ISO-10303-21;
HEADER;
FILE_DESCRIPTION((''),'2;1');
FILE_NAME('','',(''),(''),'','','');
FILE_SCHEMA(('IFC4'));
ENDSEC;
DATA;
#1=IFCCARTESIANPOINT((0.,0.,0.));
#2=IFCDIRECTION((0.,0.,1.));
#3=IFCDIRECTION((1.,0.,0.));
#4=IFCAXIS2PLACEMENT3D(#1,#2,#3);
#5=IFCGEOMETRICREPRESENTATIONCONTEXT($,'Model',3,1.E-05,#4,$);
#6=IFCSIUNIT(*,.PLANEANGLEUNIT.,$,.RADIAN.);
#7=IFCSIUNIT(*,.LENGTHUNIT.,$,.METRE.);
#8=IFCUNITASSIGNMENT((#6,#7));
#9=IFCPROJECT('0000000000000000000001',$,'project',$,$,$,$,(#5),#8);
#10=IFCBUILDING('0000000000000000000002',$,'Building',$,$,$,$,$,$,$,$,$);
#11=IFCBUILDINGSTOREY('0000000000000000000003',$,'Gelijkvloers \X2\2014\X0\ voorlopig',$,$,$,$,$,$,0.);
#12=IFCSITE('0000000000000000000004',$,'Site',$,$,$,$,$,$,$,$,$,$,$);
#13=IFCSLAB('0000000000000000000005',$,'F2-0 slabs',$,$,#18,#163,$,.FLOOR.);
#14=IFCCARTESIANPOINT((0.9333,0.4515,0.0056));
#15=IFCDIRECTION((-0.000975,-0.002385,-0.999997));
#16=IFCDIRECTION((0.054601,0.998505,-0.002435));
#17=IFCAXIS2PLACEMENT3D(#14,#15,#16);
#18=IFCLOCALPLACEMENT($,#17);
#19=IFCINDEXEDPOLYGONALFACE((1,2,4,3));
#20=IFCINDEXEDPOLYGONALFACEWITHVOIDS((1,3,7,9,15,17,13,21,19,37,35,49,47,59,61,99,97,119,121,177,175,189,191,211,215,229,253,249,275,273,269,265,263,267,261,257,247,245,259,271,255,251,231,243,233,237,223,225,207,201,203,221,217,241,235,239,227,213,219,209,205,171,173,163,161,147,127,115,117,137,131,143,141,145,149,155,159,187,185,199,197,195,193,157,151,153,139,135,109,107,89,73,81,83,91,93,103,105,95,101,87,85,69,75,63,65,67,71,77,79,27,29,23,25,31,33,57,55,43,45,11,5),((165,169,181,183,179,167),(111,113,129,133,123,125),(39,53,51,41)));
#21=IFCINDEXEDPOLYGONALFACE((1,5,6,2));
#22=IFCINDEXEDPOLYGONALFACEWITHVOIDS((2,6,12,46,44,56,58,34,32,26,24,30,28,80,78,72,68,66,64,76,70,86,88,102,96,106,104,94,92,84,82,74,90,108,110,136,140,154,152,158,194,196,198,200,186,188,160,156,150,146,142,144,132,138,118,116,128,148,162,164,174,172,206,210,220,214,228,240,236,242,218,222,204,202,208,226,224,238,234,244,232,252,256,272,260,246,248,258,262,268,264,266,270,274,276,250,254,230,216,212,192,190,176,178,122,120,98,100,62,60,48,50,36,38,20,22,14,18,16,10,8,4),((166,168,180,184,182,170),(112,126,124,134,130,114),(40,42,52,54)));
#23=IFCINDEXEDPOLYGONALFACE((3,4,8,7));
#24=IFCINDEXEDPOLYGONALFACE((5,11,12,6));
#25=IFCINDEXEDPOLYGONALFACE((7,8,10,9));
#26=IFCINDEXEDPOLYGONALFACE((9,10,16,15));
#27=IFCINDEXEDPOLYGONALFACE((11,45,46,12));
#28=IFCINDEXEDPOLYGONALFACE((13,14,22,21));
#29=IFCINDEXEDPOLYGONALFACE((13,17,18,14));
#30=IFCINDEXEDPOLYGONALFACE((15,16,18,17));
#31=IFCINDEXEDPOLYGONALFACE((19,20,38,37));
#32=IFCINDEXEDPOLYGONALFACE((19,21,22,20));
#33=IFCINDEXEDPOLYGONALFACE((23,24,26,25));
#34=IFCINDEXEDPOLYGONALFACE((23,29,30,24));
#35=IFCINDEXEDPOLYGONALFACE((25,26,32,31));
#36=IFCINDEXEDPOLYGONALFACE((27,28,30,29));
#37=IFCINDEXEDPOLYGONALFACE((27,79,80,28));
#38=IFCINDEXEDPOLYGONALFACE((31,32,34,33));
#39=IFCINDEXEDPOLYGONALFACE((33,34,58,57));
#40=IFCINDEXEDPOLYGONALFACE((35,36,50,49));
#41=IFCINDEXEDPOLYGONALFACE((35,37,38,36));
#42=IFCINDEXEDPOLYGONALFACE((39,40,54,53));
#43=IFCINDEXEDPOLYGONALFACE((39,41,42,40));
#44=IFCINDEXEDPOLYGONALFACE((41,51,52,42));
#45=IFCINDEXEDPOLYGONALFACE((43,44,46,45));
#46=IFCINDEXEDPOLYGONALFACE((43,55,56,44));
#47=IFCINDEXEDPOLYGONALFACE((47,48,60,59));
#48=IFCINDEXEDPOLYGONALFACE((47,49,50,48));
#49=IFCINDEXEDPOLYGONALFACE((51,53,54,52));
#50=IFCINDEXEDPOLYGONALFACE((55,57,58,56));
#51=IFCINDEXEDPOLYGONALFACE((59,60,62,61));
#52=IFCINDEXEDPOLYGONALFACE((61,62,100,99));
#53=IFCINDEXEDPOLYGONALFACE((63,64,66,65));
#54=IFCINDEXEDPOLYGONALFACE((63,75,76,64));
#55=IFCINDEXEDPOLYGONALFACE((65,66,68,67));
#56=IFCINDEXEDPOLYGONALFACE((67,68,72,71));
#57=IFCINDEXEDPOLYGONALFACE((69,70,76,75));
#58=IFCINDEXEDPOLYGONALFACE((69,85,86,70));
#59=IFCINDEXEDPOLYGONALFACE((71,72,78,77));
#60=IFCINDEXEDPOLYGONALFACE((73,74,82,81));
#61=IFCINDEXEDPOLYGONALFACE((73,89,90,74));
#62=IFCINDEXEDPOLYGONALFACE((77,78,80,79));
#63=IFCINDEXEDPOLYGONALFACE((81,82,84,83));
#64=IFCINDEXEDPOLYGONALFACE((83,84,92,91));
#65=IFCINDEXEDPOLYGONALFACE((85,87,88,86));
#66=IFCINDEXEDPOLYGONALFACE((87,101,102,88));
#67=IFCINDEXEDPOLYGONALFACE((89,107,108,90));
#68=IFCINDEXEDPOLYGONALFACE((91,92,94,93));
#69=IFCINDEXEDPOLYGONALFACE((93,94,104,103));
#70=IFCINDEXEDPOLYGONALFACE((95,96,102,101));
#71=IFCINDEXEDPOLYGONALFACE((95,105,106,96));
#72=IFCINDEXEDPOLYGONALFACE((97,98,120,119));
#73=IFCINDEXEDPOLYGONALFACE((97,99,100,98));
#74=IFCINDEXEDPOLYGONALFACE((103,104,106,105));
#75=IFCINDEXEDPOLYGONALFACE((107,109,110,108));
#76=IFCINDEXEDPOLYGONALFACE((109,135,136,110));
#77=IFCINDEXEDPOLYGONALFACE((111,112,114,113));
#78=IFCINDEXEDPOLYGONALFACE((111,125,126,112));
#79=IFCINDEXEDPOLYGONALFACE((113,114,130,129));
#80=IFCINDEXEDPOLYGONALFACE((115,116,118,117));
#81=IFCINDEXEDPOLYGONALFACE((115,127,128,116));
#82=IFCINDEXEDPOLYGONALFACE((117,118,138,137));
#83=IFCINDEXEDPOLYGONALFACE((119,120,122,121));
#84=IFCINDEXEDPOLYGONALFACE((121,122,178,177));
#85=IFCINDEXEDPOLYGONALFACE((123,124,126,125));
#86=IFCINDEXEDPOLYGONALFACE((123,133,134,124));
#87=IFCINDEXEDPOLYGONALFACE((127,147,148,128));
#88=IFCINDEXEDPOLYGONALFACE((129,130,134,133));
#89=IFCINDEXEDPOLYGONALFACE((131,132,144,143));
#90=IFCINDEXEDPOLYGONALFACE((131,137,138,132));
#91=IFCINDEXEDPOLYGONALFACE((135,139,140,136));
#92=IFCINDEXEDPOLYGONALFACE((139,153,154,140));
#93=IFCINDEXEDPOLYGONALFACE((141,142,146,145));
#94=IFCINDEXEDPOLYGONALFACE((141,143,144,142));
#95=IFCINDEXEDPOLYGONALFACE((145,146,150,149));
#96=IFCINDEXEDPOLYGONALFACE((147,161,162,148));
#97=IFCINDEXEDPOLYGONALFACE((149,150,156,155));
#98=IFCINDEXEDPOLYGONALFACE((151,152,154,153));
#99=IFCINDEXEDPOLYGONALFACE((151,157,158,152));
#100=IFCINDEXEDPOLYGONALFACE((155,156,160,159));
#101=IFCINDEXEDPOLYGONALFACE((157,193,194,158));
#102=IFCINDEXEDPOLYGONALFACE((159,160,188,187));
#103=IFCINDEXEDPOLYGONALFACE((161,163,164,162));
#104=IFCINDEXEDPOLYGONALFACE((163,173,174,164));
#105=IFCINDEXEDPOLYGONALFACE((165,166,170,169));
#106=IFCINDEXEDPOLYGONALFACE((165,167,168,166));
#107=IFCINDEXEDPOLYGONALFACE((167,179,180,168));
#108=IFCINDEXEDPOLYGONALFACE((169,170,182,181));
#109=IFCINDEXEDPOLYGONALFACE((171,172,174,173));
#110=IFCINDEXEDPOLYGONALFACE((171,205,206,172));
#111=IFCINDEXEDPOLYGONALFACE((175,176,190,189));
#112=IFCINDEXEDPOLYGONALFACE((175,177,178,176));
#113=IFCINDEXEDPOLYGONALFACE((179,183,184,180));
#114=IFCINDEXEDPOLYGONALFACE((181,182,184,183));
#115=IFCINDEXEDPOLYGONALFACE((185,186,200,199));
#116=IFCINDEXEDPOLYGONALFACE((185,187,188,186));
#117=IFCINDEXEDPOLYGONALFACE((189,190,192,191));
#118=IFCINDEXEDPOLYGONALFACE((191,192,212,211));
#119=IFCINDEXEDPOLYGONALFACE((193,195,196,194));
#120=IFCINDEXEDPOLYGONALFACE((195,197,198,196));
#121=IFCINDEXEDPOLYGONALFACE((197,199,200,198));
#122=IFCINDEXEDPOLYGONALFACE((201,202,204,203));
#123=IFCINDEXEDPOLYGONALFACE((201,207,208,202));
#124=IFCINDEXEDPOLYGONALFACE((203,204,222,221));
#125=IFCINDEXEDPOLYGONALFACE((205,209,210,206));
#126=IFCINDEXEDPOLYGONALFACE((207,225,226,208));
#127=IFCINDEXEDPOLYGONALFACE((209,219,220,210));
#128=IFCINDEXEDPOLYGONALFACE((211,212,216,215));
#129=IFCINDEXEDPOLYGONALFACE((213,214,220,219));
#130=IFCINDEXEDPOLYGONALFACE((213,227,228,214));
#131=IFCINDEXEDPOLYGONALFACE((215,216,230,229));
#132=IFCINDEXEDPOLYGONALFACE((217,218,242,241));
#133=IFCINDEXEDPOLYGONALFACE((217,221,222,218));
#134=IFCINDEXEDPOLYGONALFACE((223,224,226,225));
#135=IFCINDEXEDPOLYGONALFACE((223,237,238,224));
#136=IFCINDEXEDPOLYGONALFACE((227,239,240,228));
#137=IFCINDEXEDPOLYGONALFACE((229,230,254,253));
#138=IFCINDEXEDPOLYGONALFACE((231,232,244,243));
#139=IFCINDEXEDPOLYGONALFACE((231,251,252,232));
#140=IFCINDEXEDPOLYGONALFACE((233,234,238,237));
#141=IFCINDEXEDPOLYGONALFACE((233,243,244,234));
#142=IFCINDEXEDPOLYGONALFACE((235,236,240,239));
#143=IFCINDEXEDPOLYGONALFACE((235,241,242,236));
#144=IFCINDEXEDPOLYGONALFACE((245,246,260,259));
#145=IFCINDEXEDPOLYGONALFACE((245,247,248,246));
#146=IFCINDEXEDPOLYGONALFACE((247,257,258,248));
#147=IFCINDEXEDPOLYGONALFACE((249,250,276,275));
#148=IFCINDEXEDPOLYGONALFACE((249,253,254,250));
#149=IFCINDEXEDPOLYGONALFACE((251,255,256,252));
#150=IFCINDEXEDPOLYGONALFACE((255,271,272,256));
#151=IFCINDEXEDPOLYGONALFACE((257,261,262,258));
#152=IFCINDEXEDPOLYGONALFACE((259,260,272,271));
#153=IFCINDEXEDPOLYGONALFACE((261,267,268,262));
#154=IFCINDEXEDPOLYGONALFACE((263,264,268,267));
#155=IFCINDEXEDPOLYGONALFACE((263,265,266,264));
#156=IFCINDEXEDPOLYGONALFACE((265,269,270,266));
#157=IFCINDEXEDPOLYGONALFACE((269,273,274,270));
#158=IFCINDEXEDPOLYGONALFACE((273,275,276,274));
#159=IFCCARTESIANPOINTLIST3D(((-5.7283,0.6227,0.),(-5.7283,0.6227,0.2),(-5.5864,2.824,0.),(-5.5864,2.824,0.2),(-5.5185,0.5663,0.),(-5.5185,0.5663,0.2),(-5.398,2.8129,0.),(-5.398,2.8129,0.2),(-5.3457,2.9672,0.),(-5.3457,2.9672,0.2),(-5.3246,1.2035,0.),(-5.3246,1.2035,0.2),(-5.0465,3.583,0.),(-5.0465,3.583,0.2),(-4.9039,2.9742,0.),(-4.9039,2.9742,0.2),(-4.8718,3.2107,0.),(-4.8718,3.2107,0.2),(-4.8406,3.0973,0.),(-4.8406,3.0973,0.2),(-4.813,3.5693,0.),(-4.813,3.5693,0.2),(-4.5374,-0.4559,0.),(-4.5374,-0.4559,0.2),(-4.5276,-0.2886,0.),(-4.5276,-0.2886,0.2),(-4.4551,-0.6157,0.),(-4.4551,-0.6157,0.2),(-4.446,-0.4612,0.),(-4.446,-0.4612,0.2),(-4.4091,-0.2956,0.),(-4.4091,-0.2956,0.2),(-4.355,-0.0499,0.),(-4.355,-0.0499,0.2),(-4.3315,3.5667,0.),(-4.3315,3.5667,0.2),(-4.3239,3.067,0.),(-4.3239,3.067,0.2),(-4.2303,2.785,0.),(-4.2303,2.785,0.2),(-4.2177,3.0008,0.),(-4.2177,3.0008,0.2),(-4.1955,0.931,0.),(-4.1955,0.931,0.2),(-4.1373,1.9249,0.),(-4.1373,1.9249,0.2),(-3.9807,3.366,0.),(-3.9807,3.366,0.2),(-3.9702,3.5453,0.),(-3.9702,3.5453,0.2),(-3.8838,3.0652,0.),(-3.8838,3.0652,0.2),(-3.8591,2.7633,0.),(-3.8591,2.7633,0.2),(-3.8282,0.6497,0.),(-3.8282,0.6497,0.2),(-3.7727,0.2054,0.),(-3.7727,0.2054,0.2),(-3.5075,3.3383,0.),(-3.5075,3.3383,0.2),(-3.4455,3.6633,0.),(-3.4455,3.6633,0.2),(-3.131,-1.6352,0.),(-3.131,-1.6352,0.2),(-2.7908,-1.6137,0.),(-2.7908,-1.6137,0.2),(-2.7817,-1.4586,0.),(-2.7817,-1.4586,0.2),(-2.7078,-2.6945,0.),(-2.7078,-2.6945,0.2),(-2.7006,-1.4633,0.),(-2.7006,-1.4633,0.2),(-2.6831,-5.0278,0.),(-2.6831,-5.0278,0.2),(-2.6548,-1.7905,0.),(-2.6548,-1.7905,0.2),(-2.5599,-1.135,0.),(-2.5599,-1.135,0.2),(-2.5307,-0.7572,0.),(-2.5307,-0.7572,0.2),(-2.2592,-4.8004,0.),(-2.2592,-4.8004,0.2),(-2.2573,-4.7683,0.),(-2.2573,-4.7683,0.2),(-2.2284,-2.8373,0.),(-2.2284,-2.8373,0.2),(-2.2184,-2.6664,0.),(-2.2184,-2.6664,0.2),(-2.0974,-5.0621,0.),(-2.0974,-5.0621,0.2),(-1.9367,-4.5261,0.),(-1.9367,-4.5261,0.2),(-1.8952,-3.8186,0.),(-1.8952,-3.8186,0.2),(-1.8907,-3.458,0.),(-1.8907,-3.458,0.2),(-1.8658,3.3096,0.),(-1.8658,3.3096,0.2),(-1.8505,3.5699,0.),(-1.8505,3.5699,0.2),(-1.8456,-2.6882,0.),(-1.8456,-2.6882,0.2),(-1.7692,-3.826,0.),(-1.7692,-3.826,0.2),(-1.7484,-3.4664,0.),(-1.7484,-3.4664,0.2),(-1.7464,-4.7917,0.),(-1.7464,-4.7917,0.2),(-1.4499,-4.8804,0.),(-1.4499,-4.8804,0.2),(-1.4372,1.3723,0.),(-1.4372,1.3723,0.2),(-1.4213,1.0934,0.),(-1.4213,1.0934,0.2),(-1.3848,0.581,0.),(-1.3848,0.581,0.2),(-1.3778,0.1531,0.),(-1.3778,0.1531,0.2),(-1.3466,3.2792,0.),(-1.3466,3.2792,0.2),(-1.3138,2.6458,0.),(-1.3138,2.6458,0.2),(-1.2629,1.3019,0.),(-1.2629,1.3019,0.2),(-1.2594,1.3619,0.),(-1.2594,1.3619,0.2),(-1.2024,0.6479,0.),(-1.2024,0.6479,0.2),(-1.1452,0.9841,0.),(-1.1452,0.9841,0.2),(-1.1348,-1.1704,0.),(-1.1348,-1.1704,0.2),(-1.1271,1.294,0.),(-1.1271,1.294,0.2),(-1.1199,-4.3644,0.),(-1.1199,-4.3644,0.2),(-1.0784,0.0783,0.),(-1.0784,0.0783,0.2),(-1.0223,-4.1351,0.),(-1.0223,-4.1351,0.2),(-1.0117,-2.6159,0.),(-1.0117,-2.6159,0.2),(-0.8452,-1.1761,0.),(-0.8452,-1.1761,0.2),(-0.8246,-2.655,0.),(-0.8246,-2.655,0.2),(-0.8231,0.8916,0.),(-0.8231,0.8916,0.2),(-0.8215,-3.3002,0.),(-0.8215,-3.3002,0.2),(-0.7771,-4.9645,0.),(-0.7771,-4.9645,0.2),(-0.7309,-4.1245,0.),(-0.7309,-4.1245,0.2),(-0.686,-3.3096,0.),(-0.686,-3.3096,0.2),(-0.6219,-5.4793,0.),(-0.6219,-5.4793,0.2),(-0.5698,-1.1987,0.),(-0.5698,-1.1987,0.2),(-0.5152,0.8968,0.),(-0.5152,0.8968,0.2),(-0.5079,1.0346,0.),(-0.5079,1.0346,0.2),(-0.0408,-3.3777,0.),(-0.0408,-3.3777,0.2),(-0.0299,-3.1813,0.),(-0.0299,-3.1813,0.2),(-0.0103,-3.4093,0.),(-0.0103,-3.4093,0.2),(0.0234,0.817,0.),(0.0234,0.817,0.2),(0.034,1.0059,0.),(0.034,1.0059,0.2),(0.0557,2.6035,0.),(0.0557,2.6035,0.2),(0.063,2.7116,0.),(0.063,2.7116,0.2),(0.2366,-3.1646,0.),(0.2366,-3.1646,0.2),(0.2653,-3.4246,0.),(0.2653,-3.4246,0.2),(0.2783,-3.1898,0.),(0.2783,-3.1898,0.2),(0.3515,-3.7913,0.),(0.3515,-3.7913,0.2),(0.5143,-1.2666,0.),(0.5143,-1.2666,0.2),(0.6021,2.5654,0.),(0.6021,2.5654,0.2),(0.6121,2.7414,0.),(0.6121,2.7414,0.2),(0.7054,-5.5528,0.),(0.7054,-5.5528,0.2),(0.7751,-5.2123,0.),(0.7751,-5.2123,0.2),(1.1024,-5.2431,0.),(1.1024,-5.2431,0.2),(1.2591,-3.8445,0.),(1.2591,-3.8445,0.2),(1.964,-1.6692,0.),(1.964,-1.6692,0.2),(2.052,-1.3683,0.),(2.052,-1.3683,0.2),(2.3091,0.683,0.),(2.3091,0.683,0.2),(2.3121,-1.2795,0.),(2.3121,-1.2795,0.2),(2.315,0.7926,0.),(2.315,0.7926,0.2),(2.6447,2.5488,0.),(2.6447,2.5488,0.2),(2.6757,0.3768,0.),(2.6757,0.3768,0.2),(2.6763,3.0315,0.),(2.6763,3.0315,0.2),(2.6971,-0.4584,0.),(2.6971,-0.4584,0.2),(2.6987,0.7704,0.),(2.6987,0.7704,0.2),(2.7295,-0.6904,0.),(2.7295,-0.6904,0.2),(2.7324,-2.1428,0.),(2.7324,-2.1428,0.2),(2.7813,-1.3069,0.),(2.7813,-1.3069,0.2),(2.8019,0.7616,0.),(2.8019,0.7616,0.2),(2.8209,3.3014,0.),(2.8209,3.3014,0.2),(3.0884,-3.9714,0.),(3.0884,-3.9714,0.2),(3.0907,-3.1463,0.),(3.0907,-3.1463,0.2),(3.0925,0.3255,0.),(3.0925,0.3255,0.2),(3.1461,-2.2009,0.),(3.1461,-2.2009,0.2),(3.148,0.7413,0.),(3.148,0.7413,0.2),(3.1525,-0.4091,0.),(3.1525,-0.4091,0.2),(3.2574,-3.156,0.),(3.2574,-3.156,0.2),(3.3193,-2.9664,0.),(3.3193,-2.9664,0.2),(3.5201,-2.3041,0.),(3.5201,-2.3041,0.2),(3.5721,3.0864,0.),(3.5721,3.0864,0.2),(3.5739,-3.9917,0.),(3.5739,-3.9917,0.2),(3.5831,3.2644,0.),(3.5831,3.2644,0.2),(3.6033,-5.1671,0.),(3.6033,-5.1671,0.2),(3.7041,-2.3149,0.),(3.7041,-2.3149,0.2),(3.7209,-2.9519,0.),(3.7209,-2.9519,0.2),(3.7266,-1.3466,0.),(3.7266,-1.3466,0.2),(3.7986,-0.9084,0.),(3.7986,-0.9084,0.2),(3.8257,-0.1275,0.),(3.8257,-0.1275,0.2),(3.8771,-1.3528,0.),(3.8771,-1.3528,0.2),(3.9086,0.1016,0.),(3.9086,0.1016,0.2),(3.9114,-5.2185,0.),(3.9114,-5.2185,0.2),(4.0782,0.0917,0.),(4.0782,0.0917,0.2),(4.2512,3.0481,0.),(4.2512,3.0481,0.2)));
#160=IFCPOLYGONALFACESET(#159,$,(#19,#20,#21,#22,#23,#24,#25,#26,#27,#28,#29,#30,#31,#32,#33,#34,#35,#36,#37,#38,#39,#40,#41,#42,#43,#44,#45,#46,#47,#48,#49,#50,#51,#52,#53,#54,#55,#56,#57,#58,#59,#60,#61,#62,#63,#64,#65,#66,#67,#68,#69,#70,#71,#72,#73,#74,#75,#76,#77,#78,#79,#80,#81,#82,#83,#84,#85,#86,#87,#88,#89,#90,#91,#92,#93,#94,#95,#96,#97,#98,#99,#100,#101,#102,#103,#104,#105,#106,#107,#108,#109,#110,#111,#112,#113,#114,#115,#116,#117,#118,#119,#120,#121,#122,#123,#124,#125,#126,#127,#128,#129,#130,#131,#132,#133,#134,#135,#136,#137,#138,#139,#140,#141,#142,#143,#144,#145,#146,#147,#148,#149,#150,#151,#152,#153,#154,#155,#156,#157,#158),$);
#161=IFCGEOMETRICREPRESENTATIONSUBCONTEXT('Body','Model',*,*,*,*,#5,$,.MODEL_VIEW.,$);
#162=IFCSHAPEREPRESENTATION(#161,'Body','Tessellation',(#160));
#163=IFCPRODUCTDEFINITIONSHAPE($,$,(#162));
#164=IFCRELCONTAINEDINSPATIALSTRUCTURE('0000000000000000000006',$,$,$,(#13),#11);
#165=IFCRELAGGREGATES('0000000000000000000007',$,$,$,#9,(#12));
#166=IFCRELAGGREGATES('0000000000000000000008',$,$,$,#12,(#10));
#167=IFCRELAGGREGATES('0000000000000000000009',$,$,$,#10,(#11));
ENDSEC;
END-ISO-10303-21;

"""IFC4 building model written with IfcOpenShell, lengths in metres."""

from ifc_helpers import new_model, si_unit, frame, origin_with_axes, place, context, subcontext, project, spatial, polyline, outline, extrude, element, save


model = new_model("IFC4")

# Units and contexts
model_context = context("Model", 3, precision=1e-05, world=origin_with_axes())
body_context = subcontext(model_context, "Body", "Model", "MODEL_VIEW")
ifc_project = project(units=[si_unit("PLANEANGLEUNIT", "RADIAN"), si_unit("LENGTHUNIT", "METRE")], contexts=[model_context])

# Site, building, storey
site = spatial("IfcSite", under=ifc_project, Name="Site")
building = spatial("IfcBuilding", under=site, Name="Building")
storey = spatial("IfcBuildingStorey", under=building, Name="Gelijkvloers — voorlopig", Elevation=0.0)

# Slab, openings
slab_placement = place(None, frame((0.9333, 0.4515, 0.0056), z_axis=(-0.000975, -0.002385, -0.999997), x_axis=(0.054601, 0.998505, -0.002435)))
slab = element("IfcSlab", 1, at=slab_placement, inside=storey, Name="F2-0 slabs", PredefinedType="FLOOR", context=body_context, shape_type="SweptSolid", body=[
    extrude(outline(polyline([(3.5831, 3.2644), (2.8209, 3.3014), (2.6763, 3.0315), (2.6447, 2.5488), (0.6121, 2.7414), (0.6021, 2.5654), (0.0557, 2.6035), (0.063, 2.7116), (-1.3138, 2.6458), (-1.3466, 3.2792), (-1.8658, 3.3096), (-1.8505, 3.5699), (-3.4455, 3.6633), (-3.5075, 3.3383), (-3.9807, 3.366), (-3.9702, 3.5453), (-4.3315, 3.5667), (-4.3239, 3.067), (-4.8406, 3.0973), (-4.813, 3.5693), (-5.0465, 3.583), (-4.8718, 3.2107), (-4.9039, 2.9742), (-5.3457, 2.9672), (-5.398, 2.8129), (-5.5864, 2.824), (-5.7283, 0.6227), (-5.5185, 0.5663), (-5.3246, 1.2035), (-4.1373, 1.9249), (-4.1955, 0.931), (-3.8282, 0.6497), (-3.7727, 0.2054), (-4.355, -0.0499), (-4.4091, -0.2956), (-4.5276, -0.2886), (-4.5374, -0.4559), (-4.446, -0.4612), (-4.4551, -0.6157), (-2.5307, -0.7572), (-2.5599, -1.135), (-2.7006, -1.4633), (-2.7817, -1.4586), (-2.7908, -1.6137), (-3.131, -1.6352), (-2.6548, -1.7905), (-2.7078, -2.6945), (-2.2284, -2.8373), (-2.2184, -2.6664), (-1.8456, -2.6882), (-1.8907, -3.458), (-1.7484, -3.4664), (-1.7692, -3.826), (-1.8952, -3.8186), (-1.9367, -4.5261), (-2.2573, -4.7683), (-2.2592, -4.8004), (-2.6831, -5.0278), (-2.0974, -5.0621), (-1.7464, -4.7917), (-1.4499, -4.8804), (-1.1199, -4.3644), (-1.0223, -4.1351), (-0.7309, -4.1245), (-0.7771, -4.9645), (-0.6219, -5.4793), (0.7054, -5.5528), (0.7751, -5.2123), (1.1024, -5.2431), (1.2591, -3.8445), (0.3515, -3.7913), (0.5143, -1.2666), (-0.5698, -1.1987), (-0.686, -3.3096), (-0.8215, -3.3002), (-0.8246, -2.655), (-1.0117, -2.6159), (-0.8452, -1.1761), (-1.1348, -1.1704), (-1.0784, 0.0783), (-1.3778, 0.1531), (-1.3848, 0.581), (-1.2024, 0.6479), (-0.8231, 0.8916), (-0.5152, 0.8968), (-0.5079, 1.0346), (0.034, 1.0059), (0.0234, 0.817), (2.3091, 0.683), (2.315, 0.7926), (2.6987, 0.7704), (2.6757, 0.3768), (2.8019, 0.7616), (3.148, 0.7413), (3.0925, 0.3255), (3.1525, -0.4091), (2.6971, -0.4584), (2.7295, -0.6904), (2.052, -1.3683), (1.964, -1.6692), (2.3121, -1.2795), (2.7813, -1.3069), (2.7324, -2.1428), (3.1461, -2.2009), (3.0907, -3.1463), (3.2574, -3.156), (3.0884, -3.9714), (3.5739, -3.9917), (3.6033, -5.1671), (3.9114, -5.2185), (3.7209, -2.9519), (3.3193, -2.9664), (3.5201, -2.3041), (3.7041, -2.3149), (3.7266, -1.3466), (3.8771, -1.3528), (3.7986, -0.9084), (3.8257, -0.1275), (3.9086, 0.1016), (4.0782, 0.0917), (4.2512, 3.0481), (3.5721, 3.0864), (3.5831, 3.2644)])), origin_with_axes(), (0.0, 0.0, 1.0), 0.2),
])
opening_1_placement = place(slab_placement, frame((0.0, 0.0, -0.05), z_axis=(0.0, 0.0, 1.0), x_axis=(1.0, 0.0, 0.0)))
element("IfcOpeningElement", 2, at=opening_1_placement, cuts=slab, PredefinedType="OPENING", context=body_context, shape_type="SweptSolid", body=[
    extrude(outline(polyline([(0.2783, -3.1898), (0.2653, -3.4246), (-0.0103, -3.4093), (-0.0408, -3.3777), (-0.0299, -3.1813), (0.2366, -3.1646), (0.2783, -3.1898)])), origin_with_axes(), (0.0, 0.0, 1.0), 0.3),
])
opening_2_placement = place(slab_placement, frame((0.0, 0.0, -0.05), z_axis=(0.0, 0.0, 1.0), x_axis=(1.0, 0.0, 0.0)))
element("IfcOpeningElement", 3, at=opening_2_placement, cuts=slab, PredefinedType="OPENING", context=body_context, shape_type="SweptSolid", body=[
    extrude(outline(polyline([(-1.1271, 1.294), (-1.1452, 0.9841), (-1.4213, 1.0934), (-1.4372, 1.3723), (-1.2594, 1.3619), (-1.2629, 1.3019), (-1.1271, 1.294)])), origin_with_axes(), (0.0, 0.0, 1.0), 0.3),
])
opening_3_placement = place(slab_placement, frame((0.0, 0.0, -0.05), z_axis=(0.0, 0.0, 1.0), x_axis=(1.0, 0.0, 0.0)))
element("IfcOpeningElement", 4, at=opening_3_placement, cuts=slab, PredefinedType="OPENING", context=body_context, shape_type="SweptSolid", body=[
    extrude(outline(polyline([(-4.2303, 2.785), (-4.2177, 3.0008), (-3.8838, 3.0652), (-3.8591, 2.7633), (-4.2303, 2.785)])), origin_with_axes(), (0.0, 0.0, 1.0), 0.3),
])

save(model, "model.ifc")
